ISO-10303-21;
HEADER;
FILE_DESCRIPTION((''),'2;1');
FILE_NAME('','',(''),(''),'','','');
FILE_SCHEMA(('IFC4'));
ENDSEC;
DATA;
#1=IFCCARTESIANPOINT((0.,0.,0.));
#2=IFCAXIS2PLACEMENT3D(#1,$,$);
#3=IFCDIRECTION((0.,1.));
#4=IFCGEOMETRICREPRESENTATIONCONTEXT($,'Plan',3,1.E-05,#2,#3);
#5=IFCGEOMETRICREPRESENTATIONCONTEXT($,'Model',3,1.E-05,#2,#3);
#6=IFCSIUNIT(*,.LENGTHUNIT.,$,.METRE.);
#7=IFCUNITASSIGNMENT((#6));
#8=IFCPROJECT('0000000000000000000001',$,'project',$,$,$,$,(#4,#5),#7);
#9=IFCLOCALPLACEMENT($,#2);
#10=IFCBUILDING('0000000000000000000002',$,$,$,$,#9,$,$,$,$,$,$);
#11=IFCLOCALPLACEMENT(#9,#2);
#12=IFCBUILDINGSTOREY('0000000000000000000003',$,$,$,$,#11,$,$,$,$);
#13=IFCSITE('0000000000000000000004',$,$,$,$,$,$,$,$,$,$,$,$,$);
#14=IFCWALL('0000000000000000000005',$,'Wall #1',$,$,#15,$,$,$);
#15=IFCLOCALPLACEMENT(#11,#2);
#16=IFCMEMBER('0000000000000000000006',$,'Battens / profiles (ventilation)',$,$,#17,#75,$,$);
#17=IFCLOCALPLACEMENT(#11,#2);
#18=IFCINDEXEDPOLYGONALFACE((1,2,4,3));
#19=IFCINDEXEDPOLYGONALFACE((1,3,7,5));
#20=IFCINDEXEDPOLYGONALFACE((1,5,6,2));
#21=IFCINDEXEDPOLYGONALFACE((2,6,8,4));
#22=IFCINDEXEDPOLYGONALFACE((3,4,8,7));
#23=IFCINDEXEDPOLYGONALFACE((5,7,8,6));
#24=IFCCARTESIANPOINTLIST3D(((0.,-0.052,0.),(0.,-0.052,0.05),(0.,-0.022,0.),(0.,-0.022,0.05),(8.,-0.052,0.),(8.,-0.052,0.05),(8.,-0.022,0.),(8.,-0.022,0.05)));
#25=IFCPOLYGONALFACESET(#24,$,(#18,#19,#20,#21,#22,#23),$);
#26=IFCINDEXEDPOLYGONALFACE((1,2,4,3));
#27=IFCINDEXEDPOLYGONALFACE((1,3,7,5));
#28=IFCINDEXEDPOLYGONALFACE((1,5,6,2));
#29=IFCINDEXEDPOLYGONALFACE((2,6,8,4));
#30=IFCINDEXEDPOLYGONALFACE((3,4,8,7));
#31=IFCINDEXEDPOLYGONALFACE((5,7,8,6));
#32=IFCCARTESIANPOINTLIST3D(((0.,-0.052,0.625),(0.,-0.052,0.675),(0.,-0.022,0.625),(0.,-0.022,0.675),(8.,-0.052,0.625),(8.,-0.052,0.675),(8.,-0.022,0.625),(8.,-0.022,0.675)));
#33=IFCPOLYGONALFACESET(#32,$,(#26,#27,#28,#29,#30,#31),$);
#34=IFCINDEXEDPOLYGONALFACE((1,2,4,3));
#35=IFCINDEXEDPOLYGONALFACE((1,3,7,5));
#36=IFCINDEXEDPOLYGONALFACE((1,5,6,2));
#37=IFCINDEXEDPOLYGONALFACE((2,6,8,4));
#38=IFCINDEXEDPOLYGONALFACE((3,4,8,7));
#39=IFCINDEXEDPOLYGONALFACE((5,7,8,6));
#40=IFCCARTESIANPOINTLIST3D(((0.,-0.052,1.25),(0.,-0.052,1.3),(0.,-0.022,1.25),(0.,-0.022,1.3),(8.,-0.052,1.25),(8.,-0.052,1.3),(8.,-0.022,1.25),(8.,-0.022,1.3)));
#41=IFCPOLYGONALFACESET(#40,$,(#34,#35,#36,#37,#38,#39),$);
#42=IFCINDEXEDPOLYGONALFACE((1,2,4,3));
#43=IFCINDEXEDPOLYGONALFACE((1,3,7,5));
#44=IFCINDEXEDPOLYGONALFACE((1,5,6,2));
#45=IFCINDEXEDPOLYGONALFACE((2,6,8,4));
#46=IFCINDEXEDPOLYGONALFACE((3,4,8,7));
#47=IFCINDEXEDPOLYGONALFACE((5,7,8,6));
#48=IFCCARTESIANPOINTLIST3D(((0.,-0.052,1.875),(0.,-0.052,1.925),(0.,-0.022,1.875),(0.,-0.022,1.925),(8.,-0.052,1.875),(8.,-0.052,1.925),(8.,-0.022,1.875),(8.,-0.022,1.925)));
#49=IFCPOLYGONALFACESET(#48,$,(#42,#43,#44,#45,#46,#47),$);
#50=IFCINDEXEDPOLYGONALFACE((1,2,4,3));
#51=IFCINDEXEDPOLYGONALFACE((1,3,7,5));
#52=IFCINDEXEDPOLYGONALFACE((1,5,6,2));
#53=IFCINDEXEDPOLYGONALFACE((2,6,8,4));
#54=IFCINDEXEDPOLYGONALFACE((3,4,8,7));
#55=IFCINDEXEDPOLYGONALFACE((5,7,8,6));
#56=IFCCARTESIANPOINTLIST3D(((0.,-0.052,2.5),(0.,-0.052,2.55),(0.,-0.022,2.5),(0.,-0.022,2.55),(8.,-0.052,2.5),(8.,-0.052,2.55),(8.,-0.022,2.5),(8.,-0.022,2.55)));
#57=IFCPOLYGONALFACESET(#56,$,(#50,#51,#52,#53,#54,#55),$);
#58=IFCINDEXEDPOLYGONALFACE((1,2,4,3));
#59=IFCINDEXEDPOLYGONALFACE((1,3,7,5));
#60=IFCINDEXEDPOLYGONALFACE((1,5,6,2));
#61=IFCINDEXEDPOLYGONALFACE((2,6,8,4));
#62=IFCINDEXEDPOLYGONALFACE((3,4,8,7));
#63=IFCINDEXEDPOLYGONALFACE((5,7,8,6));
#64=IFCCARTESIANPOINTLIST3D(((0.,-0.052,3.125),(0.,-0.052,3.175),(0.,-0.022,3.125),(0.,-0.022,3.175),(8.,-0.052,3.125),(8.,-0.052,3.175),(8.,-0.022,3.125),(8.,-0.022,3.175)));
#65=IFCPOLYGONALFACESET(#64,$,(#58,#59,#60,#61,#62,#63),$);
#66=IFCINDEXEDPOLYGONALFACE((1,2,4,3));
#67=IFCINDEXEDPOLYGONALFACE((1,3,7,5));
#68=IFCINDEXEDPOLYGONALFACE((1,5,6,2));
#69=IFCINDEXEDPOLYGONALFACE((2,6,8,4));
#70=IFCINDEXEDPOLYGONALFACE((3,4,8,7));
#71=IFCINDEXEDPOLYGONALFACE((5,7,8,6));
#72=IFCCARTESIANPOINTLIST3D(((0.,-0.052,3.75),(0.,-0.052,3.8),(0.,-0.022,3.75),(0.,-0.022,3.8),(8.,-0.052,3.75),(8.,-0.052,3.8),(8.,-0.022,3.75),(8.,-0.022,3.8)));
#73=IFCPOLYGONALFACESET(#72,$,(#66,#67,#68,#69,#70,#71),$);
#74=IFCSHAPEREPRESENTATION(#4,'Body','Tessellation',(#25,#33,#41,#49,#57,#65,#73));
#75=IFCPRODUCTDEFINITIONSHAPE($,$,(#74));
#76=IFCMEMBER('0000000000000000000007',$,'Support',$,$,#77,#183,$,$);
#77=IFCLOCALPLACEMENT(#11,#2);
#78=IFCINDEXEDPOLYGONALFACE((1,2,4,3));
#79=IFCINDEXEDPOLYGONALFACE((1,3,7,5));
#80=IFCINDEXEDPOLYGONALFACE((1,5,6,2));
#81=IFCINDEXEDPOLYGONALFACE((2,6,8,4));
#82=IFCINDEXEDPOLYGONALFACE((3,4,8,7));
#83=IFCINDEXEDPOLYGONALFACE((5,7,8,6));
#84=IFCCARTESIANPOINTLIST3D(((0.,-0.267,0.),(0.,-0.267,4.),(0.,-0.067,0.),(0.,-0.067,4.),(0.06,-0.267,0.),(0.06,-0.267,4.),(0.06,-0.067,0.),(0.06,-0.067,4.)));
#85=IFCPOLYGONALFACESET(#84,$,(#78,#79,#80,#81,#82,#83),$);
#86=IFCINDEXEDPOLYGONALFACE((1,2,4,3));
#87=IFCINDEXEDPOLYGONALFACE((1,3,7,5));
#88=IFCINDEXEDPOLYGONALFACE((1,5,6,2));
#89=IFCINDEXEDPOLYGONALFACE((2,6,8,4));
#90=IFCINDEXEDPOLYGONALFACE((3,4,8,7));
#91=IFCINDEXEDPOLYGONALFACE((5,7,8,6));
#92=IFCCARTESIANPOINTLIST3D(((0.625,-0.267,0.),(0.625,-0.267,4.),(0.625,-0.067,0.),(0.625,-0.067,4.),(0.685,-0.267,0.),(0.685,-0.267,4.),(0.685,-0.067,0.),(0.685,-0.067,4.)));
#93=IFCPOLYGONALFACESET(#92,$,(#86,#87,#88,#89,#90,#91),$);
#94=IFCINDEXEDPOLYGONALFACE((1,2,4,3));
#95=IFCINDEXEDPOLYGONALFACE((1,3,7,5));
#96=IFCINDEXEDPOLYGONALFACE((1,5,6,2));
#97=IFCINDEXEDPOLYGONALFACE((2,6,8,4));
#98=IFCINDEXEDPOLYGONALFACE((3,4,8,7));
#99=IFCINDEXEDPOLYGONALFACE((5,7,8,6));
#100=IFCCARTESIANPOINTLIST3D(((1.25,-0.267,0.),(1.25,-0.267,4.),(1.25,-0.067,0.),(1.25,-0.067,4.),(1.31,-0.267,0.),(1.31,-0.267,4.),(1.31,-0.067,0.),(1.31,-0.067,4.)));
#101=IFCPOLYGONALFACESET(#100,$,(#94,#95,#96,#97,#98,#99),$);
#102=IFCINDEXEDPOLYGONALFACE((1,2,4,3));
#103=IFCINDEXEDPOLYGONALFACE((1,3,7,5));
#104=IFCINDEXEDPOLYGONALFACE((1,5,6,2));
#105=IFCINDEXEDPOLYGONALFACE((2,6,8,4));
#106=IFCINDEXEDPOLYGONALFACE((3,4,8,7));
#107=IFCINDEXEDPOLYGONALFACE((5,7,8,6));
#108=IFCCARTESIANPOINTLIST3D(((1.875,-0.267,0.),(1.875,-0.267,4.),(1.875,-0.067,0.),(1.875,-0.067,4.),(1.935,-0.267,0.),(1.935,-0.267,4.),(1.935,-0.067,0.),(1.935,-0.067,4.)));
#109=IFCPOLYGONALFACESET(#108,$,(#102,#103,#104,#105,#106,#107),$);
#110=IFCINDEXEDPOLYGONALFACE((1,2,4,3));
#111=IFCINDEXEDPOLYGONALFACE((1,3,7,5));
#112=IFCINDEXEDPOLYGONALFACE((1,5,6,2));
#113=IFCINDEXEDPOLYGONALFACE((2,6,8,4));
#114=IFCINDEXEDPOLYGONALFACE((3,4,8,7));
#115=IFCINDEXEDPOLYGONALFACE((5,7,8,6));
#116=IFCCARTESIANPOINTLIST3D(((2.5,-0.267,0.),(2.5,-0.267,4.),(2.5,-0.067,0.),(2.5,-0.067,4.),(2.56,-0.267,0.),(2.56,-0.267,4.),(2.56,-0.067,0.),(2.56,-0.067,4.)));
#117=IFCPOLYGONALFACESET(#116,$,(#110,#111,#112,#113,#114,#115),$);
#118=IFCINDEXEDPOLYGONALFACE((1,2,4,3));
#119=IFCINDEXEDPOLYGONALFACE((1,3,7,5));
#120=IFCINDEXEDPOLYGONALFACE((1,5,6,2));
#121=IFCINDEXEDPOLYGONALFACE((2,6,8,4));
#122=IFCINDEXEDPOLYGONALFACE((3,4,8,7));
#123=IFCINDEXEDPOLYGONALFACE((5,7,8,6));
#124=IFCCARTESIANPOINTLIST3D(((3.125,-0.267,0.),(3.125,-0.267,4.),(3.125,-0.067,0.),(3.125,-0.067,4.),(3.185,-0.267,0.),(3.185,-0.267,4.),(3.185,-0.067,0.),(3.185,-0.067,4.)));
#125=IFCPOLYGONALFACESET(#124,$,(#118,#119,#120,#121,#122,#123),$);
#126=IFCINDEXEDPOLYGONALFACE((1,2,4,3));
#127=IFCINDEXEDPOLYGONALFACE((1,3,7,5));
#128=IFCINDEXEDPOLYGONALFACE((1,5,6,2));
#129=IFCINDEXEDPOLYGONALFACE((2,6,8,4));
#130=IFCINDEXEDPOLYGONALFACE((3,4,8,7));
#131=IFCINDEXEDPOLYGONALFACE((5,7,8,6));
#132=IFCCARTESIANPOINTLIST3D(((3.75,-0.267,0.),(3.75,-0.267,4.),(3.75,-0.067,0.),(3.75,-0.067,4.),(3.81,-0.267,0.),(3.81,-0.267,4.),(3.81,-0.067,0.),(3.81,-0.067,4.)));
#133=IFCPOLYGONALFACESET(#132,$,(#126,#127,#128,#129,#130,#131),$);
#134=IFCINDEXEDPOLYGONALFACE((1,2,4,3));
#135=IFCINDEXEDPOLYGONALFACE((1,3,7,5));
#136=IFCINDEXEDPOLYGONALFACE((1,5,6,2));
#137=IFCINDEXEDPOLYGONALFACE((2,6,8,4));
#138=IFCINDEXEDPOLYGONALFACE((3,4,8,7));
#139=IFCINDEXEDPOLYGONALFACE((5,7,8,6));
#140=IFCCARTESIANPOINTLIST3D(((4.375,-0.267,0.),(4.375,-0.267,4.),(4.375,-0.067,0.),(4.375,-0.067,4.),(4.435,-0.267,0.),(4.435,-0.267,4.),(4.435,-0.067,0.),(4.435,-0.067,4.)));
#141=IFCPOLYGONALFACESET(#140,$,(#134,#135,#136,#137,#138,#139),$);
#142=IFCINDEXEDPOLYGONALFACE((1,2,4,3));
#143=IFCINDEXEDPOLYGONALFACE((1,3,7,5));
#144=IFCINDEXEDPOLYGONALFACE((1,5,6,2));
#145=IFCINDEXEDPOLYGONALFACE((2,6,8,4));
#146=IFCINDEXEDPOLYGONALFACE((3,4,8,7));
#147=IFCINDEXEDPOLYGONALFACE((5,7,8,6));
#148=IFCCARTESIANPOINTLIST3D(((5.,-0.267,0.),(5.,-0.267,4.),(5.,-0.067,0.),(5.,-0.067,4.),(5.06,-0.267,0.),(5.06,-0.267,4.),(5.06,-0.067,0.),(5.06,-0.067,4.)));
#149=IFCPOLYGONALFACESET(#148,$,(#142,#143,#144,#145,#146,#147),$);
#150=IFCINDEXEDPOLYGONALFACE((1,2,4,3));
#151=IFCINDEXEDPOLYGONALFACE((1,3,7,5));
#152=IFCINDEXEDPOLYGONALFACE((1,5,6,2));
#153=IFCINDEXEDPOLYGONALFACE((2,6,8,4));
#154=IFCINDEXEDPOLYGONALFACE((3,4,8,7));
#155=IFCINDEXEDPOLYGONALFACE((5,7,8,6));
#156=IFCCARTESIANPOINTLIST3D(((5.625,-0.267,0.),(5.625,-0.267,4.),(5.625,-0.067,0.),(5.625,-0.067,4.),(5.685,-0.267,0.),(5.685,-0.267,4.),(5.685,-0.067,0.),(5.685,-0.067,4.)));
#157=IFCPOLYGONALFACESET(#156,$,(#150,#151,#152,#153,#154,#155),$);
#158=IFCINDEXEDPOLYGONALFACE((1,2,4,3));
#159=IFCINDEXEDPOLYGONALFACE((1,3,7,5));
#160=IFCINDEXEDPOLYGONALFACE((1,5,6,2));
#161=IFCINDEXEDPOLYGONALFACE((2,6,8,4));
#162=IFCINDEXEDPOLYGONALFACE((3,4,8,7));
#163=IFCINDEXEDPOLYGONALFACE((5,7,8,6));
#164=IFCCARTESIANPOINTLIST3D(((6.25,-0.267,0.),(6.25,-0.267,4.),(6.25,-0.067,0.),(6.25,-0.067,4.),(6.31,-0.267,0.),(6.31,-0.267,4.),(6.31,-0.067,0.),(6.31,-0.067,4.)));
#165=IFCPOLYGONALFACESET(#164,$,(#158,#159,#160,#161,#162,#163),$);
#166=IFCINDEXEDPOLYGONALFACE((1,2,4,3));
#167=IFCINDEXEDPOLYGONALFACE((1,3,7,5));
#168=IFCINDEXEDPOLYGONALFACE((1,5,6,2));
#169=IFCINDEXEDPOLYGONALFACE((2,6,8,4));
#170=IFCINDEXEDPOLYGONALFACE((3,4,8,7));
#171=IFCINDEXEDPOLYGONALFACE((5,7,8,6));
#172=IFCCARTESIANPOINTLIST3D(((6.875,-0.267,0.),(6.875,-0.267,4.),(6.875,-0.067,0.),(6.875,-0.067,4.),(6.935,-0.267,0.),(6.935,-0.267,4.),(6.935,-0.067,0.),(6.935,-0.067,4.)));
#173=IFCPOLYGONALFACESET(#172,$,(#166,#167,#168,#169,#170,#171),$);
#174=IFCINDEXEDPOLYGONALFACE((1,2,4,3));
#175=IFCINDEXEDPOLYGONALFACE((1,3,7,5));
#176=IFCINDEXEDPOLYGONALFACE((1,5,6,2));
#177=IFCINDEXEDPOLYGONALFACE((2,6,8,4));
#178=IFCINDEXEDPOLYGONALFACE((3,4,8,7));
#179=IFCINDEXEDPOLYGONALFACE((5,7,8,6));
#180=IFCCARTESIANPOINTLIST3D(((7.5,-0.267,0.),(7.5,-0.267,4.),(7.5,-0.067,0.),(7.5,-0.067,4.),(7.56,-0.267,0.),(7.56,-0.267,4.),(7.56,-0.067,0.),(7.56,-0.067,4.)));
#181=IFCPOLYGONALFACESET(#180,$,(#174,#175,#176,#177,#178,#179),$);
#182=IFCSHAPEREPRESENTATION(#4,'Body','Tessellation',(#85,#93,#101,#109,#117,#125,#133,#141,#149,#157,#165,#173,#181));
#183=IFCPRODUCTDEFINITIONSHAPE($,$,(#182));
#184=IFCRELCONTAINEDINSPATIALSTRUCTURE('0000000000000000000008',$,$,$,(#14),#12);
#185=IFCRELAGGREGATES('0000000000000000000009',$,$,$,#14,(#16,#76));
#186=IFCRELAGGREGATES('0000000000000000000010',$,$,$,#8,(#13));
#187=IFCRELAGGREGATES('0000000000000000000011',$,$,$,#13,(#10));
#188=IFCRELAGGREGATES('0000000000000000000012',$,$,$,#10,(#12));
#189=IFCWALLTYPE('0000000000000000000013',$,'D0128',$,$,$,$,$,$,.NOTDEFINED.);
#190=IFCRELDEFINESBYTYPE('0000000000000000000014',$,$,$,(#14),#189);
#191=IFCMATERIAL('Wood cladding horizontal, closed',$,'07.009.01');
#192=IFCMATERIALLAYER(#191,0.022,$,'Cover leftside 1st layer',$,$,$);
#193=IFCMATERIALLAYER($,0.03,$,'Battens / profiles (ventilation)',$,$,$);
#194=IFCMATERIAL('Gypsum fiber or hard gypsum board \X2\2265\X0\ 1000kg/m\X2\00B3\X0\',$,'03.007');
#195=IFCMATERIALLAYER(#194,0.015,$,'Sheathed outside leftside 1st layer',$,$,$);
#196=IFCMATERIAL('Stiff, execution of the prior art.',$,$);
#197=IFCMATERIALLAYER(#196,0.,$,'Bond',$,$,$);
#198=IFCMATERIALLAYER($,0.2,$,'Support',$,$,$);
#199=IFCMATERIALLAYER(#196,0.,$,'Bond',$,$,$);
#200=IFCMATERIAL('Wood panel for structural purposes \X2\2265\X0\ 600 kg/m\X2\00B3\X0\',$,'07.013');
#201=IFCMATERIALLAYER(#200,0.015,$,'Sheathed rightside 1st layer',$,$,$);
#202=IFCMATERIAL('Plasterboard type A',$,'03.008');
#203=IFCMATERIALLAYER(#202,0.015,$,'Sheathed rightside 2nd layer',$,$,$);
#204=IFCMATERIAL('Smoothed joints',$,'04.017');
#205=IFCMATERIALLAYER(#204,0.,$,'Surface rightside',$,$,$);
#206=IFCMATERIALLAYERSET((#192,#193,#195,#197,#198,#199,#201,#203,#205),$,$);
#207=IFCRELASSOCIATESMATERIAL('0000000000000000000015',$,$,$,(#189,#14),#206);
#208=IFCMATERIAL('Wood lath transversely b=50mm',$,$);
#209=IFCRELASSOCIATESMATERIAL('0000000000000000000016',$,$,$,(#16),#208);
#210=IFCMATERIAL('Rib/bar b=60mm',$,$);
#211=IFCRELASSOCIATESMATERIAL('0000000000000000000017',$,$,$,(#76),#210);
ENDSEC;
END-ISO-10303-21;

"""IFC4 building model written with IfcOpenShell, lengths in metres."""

from ifc_helpers import new_model, si_unit, direction, frame, frame_2d, origin, place, context, project, spatial, rectangle, extrude, material, layer, layer_set, type_object, element, aggregate, save


model = new_model("IFC4")

# Units and contexts
plan_context = context("Plan", 3, precision=1e-05, world=origin(), true_north=direction((0.0, 1.0)))
model_context = context("Model", 3, precision=1e-05, world=origin(), true_north=direction((0.0, 1.0)))
ifc_project = project(units=[si_unit("LENGTHUNIT", "METRE")], contexts=[plan_context, model_context])

# Site, building, storey
site = spatial("IfcSite", under=ifc_project)
building_placement = place(None, origin())
building = spatial("IfcBuilding", under=site, at=building_placement)
storey_placement = place(building_placement, origin())
storey = spatial("IfcBuildingStorey", under=building, at=storey_placement)

# Wall, members
ifc_material_1 = material(Name="Wood cladding horizontal, closed", Category="07.009.01")
ifc_layer_1 = layer(ifc_material_1, 0.022, Name="Cover leftside 1st layer")
ifc_layer_2 = layer(None, 0.03, Name="Battens / profiles (ventilation)")
ifc_material_2 = material(Name="Gypsum fiber or hard gypsum board ≥ 1000kg/m³", Category="03.007")
ifc_layer_3 = layer(ifc_material_2, 0.015, Name="Sheathed outside leftside 1st layer")
ifc_material_3 = material(Name="Stiff, execution of the prior art.")
ifc_layer_4 = layer(ifc_material_3, 0.0, Name="Bond")
ifc_layer_5 = layer(None, 0.2, Name="Support")
ifc_layer_6 = layer(ifc_material_3, 0.0, Name="Bond")
ifc_material_4 = material(Name="Wood panel for structural purposes ≥ 600 kg/m³", Category="07.013")
ifc_layer_7 = layer(ifc_material_4, 0.015, Name="Sheathed rightside 1st layer")
ifc_material_5 = material(Name="Plasterboard type A", Category="03.008")
ifc_layer_8 = layer(ifc_material_5, 0.015, Name="Sheathed rightside 2nd layer")
ifc_material_6 = material(Name="Smoothed joints", Category="04.017")
ifc_layer_9 = layer(ifc_material_6, 0.0, Name="Surface rightside")
ifc_layer_set = layer_set([ifc_layer_1, ifc_layer_2, ifc_layer_3, ifc_layer_4, ifc_layer_5, ifc_layer_6, ifc_layer_7, ifc_layer_8, ifc_layer_9])
wall_type = type_object("IfcWallType", Name="D0128", PredefinedType="NOTDEFINED", material=ifc_layer_set)
wall_placement = place(None, frame((0.0, 0.0, 0.0), z_axis=(0.0, -1.0, 0.0), x_axis=(1.0, 0.0, 0.0)))
wall = element("IfcWall", 1, at=wall_placement, inside=storey, type_object=wall_type, material=ifc_layer_set, Name="Wall #1")
ifc_material_7 = material(Name="Wood lath transversely b=50mm")
member_1_placement = place(wall_placement, origin())
member_1 = element("IfcMember", 2, at=member_1_placement, material=ifc_material_7, Name="Battens / profiles (ventilation)", context=plan_context, shape_type="SweptSolid", body=[
    extrude(rectangle(XDim=0.05, YDim=0.03, at=frame_2d((0.025, 0.015), x_axis=(1.0, 0.0))), frame((0.0, 0.0, 0.022), z_axis=(1.0, 0.0, 0.0), x_axis=(0.0, 1.0, 0.0)), (0.0, 0.0, 1.0), 8.0),
    extrude(rectangle(XDim=0.05, YDim=0.03, at=frame_2d((0.025, 0.015), x_axis=(1.0, 0.0))), frame((0.0, 0.625, 0.022), z_axis=(1.0, 0.0, 0.0), x_axis=(0.0, 1.0, 0.0)), (0.0, 0.0, 1.0), 8.0),
    extrude(rectangle(XDim=0.05, YDim=0.03, at=frame_2d((0.025, 0.015), x_axis=(1.0, 0.0))), frame((0.0, 1.25, 0.022), z_axis=(1.0, 0.0, 0.0), x_axis=(0.0, 1.0, 0.0)), (0.0, 0.0, 1.0), 8.0),
    extrude(rectangle(XDim=0.05, YDim=0.03, at=frame_2d((0.025, 0.015), x_axis=(1.0, 0.0))), frame((0.0, 1.875, 0.022), z_axis=(1.0, 0.0, 0.0), x_axis=(0.0, 1.0, 0.0)), (0.0, 0.0, 1.0), 8.0),
    extrude(rectangle(XDim=0.05, YDim=0.03, at=frame_2d((0.025, 0.015), x_axis=(1.0, 0.0))), frame((0.0, 2.5, 0.022), z_axis=(1.0, 0.0, 0.0), x_axis=(0.0, 1.0, 0.0)), (0.0, 0.0, 1.0), 8.0),
    extrude(rectangle(XDim=0.05, YDim=0.03, at=frame_2d((0.025, 0.015), x_axis=(1.0, 0.0))), frame((0.0, 3.125, 0.022), z_axis=(1.0, 0.0, 0.0), x_axis=(0.0, 1.0, 0.0)), (0.0, 0.0, 1.0), 8.0),
    extrude(rectangle(XDim=0.05, YDim=0.03, at=frame_2d((0.025, 0.015), x_axis=(1.0, 0.0))), frame((0.0, 3.75, 0.022), z_axis=(1.0, 0.0, 0.0), x_axis=(0.0, 1.0, 0.0)), (0.0, 0.0, 1.0), 8.0),
])
ifc_material_8 = material(Name="Rib/bar b=60mm")
member_2_placement = place(wall_placement, origin())
member_2 = element("IfcMember", 3, at=member_2_placement, material=ifc_material_8, Name="Support", context=plan_context, shape_type="SweptSolid", body=[
    extrude(rectangle(XDim=0.06, YDim=0.2, at=frame_2d((0.03, 0.1), x_axis=(1.0, 0.0))), frame((0.0, 4.0, 0.067), z_axis=(0.0, -1.0, 0.0), x_axis=(1.0, 0.0, 0.0)), (0.0, 0.0, 1.0), 4.0),
    extrude(rectangle(XDim=0.06, YDim=0.2, at=frame_2d((0.03, 0.1), x_axis=(1.0, 0.0))), frame((0.625, 4.0, 0.067), z_axis=(0.0, -1.0, 0.0), x_axis=(1.0, 0.0, 0.0)), (0.0, 0.0, 1.0), 4.0),
    extrude(rectangle(XDim=0.06, YDim=0.2, at=frame_2d((0.03, 0.1), x_axis=(1.0, 0.0))), frame((1.25, 4.0, 0.067), z_axis=(0.0, -1.0, 0.0), x_axis=(1.0, 0.0, 0.0)), (0.0, 0.0, 1.0), 4.0),
    extrude(rectangle(XDim=0.06, YDim=0.2, at=frame_2d((0.03, 0.1), x_axis=(1.0, 0.0))), frame((1.875, 4.0, 0.067), z_axis=(0.0, -1.0, 0.0), x_axis=(1.0, 0.0, 0.0)), (0.0, 0.0, 1.0), 4.0),
    extrude(rectangle(XDim=0.06, YDim=0.2, at=frame_2d((0.03, 0.1), x_axis=(1.0, 0.0))), frame((2.5, 4.0, 0.067), z_axis=(0.0, -1.0, 0.0), x_axis=(1.0, 0.0, 0.0)), (0.0, 0.0, 1.0), 4.0),
    extrude(rectangle(XDim=0.06, YDim=0.2, at=frame_2d((0.03, 0.1), x_axis=(1.0, 0.0))), frame((3.125, 4.0, 0.067), z_axis=(0.0, -1.0, 0.0), x_axis=(1.0, 0.0, 0.0)), (0.0, 0.0, 1.0), 4.0),
    extrude(rectangle(XDim=0.06, YDim=0.2, at=frame_2d((0.03, 0.1), x_axis=(1.0, 0.0))), frame((3.75, 4.0, 0.067), z_axis=(0.0, -1.0, 0.0), x_axis=(1.0, 0.0, 0.0)), (0.0, 0.0, 1.0), 4.0),
    extrude(rectangle(XDim=0.06, YDim=0.2, at=frame_2d((0.03, 0.1), x_axis=(1.0, 0.0))), frame((4.375, 4.0, 0.067), z_axis=(0.0, -1.0, 0.0), x_axis=(1.0, 0.0, 0.0)), (0.0, 0.0, 1.0), 4.0),
    extrude(rectangle(XDim=0.06, YDim=0.2, at=frame_2d((0.03, 0.1), x_axis=(1.0, 0.0))), frame((5.0, 4.0, 0.067), z_axis=(0.0, -1.0, 0.0), x_axis=(1.0, 0.0, 0.0)), (0.0, 0.0, 1.0), 4.0),
    extrude(rectangle(XDim=0.06, YDim=0.2, at=frame_2d((0.03, 0.1), x_axis=(1.0, 0.0))), frame((5.625, 4.0, 0.067), z_axis=(0.0, -1.0, 0.0), x_axis=(1.0, 0.0, 0.0)), (0.0, 0.0, 1.0), 4.0),
    extrude(rectangle(XDim=0.06, YDim=0.2, at=frame_2d((0.03, 0.1), x_axis=(1.0, 0.0))), frame((6.25, 4.0, 0.067), z_axis=(0.0, -1.0, 0.0), x_axis=(1.0, 0.0, 0.0)), (0.0, 0.0, 1.0), 4.0),
    extrude(rectangle(XDim=0.06, YDim=0.2, at=frame_2d((0.03, 0.1), x_axis=(1.0, 0.0))), frame((6.875, 4.0, 0.067), z_axis=(0.0, -1.0, 0.0), x_axis=(1.0, 0.0, 0.0)), (0.0, 0.0, 1.0), 4.0),
    extrude(rectangle(XDim=0.06, YDim=0.2, at=frame_2d((0.03, 0.1), x_axis=(1.0, 0.0))), frame((7.5, 4.0, 0.067), z_axis=(0.0, -1.0, 0.0), x_axis=(1.0, 0.0, 0.0)), (0.0, 0.0, 1.0), 4.0),
])
aggregate(wall, [member_1, member_2])

save(model, "model.ifc")
